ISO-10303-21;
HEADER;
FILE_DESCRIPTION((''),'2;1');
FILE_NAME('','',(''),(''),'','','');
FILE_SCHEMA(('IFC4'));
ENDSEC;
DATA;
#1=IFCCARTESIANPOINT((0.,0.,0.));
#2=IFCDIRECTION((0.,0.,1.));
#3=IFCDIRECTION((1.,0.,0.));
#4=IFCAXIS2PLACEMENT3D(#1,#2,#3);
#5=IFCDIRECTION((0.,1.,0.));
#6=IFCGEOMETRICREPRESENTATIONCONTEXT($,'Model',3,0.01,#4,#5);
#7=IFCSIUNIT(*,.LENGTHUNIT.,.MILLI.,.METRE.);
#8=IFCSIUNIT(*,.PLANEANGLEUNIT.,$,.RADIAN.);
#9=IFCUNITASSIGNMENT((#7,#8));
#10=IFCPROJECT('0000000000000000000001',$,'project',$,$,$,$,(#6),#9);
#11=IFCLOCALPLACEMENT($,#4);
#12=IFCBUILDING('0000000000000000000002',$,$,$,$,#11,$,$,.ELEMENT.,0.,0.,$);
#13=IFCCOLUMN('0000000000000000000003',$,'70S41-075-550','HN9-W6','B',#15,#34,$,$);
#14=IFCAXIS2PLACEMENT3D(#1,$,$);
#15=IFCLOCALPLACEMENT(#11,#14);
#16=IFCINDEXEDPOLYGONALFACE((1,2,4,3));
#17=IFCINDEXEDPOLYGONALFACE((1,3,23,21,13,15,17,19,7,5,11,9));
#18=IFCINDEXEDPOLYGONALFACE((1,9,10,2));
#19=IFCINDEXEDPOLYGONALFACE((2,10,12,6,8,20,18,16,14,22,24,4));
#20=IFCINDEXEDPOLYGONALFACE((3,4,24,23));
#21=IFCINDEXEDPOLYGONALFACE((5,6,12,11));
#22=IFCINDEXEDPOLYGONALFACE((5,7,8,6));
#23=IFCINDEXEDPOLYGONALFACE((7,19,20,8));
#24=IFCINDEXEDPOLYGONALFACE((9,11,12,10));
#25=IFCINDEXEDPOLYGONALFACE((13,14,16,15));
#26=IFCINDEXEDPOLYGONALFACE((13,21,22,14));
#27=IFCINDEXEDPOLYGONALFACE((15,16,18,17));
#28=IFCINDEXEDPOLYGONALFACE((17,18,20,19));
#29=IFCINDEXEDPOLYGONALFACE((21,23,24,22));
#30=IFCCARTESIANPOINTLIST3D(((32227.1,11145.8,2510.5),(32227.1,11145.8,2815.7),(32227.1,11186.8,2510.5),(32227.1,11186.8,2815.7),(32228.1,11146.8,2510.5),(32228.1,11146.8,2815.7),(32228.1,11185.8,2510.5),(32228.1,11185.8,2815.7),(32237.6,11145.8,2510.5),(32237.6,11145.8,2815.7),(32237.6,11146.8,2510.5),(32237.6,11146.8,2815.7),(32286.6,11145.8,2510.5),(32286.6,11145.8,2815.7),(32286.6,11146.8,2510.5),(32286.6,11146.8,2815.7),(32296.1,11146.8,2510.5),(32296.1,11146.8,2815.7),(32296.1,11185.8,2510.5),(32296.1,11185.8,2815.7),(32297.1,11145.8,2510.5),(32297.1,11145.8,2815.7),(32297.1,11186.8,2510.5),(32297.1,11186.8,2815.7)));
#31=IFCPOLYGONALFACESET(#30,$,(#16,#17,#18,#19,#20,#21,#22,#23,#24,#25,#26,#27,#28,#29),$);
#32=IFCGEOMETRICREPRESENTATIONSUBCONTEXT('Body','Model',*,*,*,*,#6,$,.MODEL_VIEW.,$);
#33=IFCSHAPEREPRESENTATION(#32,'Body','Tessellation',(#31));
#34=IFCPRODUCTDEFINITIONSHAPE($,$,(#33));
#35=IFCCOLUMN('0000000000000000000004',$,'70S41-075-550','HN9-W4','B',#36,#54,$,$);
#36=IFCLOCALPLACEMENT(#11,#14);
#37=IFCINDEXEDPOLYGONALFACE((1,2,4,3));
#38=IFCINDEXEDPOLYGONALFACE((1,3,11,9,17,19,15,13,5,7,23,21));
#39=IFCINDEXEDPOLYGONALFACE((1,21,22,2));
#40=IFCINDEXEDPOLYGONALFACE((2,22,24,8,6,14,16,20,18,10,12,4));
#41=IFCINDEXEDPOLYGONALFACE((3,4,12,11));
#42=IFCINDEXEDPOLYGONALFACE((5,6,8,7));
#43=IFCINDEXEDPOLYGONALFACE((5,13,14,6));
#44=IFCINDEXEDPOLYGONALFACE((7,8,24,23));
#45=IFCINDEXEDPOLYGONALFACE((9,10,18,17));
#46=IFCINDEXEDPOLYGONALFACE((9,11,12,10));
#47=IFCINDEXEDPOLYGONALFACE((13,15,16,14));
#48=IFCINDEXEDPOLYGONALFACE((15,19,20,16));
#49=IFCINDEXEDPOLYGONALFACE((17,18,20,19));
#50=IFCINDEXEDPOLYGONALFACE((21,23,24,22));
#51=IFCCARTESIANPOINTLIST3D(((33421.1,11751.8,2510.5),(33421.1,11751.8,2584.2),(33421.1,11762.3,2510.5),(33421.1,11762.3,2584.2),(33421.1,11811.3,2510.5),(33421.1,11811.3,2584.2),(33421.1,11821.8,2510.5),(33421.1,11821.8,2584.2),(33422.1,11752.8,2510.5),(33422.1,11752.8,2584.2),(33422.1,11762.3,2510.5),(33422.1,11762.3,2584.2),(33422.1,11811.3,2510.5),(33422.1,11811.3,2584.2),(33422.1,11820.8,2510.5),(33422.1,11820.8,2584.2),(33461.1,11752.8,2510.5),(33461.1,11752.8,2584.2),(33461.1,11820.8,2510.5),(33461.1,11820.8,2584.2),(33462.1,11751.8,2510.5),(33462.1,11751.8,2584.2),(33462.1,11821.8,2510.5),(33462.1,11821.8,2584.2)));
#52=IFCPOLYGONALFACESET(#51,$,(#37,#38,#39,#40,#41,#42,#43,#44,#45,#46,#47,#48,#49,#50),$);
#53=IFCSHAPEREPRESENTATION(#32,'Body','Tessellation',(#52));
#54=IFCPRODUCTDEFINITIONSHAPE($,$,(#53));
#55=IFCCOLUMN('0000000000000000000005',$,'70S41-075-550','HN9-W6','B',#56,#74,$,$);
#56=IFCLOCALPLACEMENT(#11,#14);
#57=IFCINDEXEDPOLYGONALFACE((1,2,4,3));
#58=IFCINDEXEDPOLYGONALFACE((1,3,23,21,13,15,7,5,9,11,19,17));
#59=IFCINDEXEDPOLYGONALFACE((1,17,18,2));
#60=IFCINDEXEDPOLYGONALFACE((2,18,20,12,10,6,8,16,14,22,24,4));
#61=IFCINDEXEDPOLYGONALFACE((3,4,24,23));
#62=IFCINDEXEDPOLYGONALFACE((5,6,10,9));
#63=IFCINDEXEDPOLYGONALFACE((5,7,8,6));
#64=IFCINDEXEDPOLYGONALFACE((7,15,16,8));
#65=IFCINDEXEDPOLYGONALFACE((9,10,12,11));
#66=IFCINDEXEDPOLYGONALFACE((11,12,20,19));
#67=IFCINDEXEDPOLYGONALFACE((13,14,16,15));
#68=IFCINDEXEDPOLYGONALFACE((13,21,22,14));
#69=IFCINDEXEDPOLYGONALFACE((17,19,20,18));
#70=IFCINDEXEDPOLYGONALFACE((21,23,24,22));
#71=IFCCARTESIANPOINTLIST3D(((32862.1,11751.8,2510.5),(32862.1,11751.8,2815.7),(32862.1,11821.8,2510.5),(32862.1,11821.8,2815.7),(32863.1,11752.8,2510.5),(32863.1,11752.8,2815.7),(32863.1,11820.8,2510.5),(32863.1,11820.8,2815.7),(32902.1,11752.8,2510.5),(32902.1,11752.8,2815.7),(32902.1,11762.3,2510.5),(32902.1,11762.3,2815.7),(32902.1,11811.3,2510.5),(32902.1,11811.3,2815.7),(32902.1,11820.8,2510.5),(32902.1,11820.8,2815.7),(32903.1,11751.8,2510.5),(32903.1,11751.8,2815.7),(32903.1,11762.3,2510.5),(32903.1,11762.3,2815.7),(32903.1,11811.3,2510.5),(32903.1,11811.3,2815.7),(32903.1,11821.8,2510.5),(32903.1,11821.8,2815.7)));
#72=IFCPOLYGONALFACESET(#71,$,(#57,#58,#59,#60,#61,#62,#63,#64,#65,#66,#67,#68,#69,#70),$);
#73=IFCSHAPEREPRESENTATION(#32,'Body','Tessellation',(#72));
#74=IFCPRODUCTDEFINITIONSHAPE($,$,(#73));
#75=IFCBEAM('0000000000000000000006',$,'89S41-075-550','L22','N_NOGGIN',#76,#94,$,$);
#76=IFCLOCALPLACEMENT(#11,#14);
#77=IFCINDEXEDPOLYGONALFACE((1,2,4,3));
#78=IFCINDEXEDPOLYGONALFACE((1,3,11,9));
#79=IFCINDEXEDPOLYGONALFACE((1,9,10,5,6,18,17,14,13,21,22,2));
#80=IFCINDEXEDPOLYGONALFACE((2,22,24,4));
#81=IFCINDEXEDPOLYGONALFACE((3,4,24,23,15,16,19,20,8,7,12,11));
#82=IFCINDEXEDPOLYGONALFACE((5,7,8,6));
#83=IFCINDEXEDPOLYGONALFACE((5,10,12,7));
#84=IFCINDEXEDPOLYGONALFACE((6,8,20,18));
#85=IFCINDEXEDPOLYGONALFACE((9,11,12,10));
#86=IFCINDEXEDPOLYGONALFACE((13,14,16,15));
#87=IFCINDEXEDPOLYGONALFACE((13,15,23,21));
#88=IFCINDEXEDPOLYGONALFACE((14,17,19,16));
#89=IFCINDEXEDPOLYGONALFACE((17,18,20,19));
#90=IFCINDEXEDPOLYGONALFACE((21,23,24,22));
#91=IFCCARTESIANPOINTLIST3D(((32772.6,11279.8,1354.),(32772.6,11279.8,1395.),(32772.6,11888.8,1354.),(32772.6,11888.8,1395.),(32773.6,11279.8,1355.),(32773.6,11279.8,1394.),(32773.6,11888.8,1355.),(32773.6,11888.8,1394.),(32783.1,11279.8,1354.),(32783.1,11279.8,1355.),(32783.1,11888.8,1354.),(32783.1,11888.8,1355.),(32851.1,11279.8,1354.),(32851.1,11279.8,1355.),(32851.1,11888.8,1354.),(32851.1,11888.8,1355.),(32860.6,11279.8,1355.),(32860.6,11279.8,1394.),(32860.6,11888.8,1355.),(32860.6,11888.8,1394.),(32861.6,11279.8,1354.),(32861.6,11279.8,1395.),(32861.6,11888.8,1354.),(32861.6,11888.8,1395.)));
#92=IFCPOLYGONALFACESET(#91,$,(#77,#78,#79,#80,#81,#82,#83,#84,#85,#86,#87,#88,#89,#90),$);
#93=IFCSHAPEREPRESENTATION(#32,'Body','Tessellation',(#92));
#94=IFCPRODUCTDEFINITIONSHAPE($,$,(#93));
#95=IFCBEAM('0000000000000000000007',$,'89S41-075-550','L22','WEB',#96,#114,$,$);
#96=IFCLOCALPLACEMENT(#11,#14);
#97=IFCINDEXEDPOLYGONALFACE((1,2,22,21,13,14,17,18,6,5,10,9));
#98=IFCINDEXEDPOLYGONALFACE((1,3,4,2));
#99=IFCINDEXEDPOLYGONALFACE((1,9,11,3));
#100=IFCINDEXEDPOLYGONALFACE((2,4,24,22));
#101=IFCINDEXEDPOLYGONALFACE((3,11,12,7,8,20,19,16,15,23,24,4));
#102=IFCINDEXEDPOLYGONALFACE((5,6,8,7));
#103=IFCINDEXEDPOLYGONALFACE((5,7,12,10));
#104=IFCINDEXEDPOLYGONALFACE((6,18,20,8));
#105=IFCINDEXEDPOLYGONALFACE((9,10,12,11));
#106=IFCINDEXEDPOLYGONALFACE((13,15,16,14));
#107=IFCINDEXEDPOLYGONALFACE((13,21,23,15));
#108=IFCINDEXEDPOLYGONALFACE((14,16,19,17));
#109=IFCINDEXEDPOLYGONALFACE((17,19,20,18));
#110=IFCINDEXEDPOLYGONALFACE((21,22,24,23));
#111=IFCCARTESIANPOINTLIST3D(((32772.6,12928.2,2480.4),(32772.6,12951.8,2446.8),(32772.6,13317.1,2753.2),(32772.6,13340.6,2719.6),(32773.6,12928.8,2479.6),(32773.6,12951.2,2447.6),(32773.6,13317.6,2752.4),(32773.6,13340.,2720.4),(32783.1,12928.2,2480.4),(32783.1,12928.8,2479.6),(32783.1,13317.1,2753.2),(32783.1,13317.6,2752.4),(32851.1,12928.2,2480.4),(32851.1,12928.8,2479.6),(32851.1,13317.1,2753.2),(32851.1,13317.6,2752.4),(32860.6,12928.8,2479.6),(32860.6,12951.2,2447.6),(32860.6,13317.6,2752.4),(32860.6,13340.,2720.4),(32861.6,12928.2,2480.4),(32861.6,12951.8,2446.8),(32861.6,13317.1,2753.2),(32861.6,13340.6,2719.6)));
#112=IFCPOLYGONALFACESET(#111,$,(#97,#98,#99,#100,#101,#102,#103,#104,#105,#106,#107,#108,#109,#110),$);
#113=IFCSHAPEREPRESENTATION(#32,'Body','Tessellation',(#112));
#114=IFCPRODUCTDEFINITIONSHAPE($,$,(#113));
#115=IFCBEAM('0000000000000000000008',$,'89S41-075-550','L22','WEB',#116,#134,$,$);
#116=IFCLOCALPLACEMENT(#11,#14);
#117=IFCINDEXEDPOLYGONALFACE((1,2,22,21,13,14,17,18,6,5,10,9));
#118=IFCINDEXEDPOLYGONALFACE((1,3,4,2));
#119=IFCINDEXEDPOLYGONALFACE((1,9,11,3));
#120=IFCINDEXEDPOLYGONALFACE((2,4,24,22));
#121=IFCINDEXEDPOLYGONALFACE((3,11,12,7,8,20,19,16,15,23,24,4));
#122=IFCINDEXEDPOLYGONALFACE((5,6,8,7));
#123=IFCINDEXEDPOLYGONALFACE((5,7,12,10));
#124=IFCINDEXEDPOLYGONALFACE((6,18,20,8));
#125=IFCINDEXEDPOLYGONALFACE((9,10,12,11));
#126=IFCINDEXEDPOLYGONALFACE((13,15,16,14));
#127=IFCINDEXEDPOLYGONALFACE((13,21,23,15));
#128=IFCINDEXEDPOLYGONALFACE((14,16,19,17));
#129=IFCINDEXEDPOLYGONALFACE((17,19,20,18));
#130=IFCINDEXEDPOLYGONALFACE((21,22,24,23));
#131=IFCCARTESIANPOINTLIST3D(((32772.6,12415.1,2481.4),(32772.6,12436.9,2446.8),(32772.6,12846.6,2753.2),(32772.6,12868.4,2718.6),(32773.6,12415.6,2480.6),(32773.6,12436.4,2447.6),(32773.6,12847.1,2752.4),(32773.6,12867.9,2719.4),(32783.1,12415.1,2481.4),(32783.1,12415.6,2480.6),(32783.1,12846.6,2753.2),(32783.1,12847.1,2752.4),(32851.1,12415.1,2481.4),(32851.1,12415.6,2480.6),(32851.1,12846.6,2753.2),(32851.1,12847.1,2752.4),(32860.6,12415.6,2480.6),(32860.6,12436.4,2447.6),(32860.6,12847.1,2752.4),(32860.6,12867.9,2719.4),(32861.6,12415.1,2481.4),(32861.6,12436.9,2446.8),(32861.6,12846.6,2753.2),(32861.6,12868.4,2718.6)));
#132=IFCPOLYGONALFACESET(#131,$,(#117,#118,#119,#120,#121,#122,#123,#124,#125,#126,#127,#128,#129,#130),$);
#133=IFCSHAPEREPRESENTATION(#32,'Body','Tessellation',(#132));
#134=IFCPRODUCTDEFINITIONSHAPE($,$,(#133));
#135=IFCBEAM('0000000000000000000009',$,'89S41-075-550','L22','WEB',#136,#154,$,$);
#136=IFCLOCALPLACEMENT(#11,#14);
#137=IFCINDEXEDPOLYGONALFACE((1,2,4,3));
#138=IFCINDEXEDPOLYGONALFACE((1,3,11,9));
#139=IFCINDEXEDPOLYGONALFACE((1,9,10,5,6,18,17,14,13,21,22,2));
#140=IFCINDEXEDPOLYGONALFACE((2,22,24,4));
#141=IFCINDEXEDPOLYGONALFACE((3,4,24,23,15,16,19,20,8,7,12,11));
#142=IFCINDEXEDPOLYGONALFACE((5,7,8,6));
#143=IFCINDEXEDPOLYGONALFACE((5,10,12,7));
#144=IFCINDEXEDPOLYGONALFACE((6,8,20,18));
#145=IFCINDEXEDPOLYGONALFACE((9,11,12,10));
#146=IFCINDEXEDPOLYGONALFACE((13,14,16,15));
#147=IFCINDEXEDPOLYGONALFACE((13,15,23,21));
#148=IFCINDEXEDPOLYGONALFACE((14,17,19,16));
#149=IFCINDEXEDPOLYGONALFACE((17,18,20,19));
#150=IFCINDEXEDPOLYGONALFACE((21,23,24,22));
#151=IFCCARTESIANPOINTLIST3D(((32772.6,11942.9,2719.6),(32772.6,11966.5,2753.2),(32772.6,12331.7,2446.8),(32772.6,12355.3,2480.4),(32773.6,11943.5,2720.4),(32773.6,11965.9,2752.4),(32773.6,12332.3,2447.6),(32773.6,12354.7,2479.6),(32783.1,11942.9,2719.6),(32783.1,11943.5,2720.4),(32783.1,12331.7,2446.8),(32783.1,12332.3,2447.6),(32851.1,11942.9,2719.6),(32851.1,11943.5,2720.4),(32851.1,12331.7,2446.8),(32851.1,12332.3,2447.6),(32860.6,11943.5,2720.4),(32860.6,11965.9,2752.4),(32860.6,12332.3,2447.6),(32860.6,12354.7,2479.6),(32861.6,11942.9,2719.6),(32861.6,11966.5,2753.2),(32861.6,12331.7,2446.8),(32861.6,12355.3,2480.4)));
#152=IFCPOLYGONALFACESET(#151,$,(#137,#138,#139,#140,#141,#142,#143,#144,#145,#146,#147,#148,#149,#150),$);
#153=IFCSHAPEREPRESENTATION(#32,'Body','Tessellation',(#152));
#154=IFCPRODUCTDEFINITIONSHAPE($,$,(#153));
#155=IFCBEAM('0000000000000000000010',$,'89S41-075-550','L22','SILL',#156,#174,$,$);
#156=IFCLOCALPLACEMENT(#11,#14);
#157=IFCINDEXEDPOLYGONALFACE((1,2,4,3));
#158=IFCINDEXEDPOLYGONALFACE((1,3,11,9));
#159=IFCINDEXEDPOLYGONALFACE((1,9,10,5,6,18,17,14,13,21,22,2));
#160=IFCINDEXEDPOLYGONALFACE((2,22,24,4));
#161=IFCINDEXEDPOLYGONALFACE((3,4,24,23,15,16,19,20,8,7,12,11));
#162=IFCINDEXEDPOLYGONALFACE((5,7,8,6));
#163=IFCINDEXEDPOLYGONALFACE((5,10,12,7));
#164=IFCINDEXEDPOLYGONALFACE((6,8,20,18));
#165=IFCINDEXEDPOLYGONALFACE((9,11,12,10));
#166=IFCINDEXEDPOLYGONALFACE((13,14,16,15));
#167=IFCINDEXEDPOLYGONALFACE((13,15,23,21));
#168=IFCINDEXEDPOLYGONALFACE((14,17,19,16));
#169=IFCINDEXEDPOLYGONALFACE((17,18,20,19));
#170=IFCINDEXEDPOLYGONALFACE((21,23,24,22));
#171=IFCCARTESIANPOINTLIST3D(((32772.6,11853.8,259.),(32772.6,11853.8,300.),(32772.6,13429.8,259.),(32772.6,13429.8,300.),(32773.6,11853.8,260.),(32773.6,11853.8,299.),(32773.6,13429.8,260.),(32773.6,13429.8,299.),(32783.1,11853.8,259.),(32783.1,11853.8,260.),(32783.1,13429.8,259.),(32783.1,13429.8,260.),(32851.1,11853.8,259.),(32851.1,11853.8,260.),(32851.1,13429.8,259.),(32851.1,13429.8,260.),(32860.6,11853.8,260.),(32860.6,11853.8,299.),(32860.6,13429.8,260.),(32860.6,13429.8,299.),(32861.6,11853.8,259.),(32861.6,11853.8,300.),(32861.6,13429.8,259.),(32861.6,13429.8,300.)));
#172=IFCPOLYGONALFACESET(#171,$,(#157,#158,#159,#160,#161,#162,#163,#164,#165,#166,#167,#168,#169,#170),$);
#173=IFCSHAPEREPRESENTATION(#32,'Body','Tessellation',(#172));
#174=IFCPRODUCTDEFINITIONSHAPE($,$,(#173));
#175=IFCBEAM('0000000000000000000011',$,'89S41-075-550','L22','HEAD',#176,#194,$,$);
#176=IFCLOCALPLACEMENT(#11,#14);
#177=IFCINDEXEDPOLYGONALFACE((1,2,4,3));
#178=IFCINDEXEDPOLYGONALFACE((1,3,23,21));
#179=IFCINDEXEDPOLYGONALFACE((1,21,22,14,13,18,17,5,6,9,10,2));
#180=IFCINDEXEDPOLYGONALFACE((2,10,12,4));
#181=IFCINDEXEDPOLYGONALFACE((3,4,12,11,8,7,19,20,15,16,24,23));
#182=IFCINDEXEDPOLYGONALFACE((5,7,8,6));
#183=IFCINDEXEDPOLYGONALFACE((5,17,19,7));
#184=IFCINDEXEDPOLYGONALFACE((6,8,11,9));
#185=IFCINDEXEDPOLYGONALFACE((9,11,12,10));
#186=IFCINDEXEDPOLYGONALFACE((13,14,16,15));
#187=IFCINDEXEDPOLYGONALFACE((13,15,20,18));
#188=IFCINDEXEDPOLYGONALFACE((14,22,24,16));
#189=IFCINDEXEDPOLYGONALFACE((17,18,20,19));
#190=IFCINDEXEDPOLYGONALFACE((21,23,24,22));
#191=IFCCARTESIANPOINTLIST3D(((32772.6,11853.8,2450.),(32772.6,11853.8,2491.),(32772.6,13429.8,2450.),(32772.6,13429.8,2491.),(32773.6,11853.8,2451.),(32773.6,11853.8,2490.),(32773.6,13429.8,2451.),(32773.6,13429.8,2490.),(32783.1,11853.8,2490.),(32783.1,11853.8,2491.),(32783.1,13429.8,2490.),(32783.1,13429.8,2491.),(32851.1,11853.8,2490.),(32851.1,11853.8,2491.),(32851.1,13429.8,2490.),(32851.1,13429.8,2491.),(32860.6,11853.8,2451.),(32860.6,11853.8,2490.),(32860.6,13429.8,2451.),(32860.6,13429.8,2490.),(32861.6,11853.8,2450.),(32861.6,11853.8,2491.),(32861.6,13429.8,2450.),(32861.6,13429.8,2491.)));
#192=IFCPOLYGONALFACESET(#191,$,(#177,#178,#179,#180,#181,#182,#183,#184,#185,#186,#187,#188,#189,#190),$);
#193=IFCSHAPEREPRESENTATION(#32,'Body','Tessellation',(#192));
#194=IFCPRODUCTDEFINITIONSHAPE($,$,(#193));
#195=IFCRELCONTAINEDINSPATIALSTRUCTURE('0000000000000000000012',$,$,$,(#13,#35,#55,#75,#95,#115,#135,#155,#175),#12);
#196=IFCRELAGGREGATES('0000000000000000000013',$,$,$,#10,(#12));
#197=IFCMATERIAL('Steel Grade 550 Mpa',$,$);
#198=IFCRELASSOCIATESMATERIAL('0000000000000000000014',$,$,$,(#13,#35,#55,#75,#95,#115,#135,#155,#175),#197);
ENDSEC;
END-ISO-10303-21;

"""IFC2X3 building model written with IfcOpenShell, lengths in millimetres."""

from ifc_helpers import new_model, si_unit, direction, frame, origin, origin_with_axes, origin_2d_with_axis, place, context, subcontext, project, spatial, c_section, extrude, source, transform, mapped, material, element, save


model = new_model("IFC2X3")

# Units and contexts
model_context = context("Model", 3, precision=0.01, world=origin_with_axes(), true_north=direction((0.0, 1.0, 0.0)))
body_context = subcontext(model_context, "Body", "Model", "MODEL_VIEW")
ifc_project = project(units=[si_unit("LENGTHUNIT", "METRE", prefix="MILLI"), si_unit("PLANEANGLEUNIT", "RADIAN")], contexts=[model_context])

# Building
building_placement = place(None, origin_with_axes())
building = spatial("IfcBuilding", under=ifc_project, at=building_placement, CompositionType="ELEMENT", ElevationOfRefHeight=0.0, ElevationOfTerrain=0.0)

# Columns
ifc_material = material(Name="Steel Grade 550 Mpa")
shared_shape_1 = source(origin(), body_context, "Body", "SweptSolid", [
    extrude(c_section(Depth=70.0, Width=41.0, WallThickness=1.0, Girth=10.5, at=origin_2d_with_axis()), origin_with_axes(), (0.0, 0.0, 1.0), 305.2),
])
column_1_placement = place(None, frame((32262.1, 11166.3, 2510.5), z_axis=(0.0, 0.0, 1.0), x_axis=(0.0, -1.0, 0.0)))
element("IfcColumn", 1, at=column_1_placement, inside=building, material=ifc_material, Name="70S41-075-550", Description="HN9-W6", ObjectType="B", context=body_context, shape_type="MappedRepresentation", body=[
    mapped(shared_shape_1, transform((0.0, 0.0, 0.0), scale=1.0)),
])
shared_shape_2 = source(origin(), body_context, "Body", "SweptSolid", [
    extrude(c_section(Depth=70.0, Width=41.0, WallThickness=1.0, Girth=10.5, at=origin_2d_with_axis()), origin_with_axes(), (0.0, 0.0, 1.0), 73.7),
])
column_2_placement = place(None, frame((33441.6, 11786.8, 2584.2), z_axis=(0.0, 0.0, -1.0), x_axis=(-1.0, 0.0, 0.0)))
element("IfcColumn", 2, at=column_2_placement, inside=building, material=ifc_material, Name="70S41-075-550", Description="HN9-W4", ObjectType="B", context=body_context, shape_type="MappedRepresentation", body=[
    mapped(shared_shape_2, transform((0.0, 0.0, 0.0), scale=1.0)),
])
shared_shape_3 = source(origin(), body_context, "Body", "SweptSolid", [
    extrude(c_section(Depth=70.0, Width=41.0, WallThickness=1.0, Girth=10.5, at=origin_2d_with_axis()), origin_with_axes(), (0.0, 0.0, 1.0), 305.2),
])
column_3_placement = place(None, frame((32882.6, 11786.8, 2510.5), z_axis=(0.0, 0.0, 1.0), x_axis=(1.0, 0.0, 0.0)))
element("IfcColumn", 3, at=column_3_placement, inside=building, material=ifc_material, Name="70S41-075-550", Description="HN9-W6", ObjectType="B", context=body_context, shape_type="MappedRepresentation", body=[
    mapped(shared_shape_3, transform((0.0, 0.0, 0.0), scale=1.0)),
])

# Beams
shared_shape_4 = source(origin(), body_context, "Body", "SweptSolid", [
    extrude(c_section(Depth=89.0, Width=41.0, WallThickness=1.0, Girth=10.5, at=origin_2d_with_axis()), origin_with_axes(), (0.0, 0.0, 1.0), 609.0),
])
beam_1_placement = place(None, frame((32817.1, 11279.8, 1374.5), z_axis=(0.0, 1.0, 0.0), x_axis=(0.0, 0.0, -1.0)))
element("IfcBeam", 4, at=beam_1_placement, inside=building, material=ifc_material, Name="89S41-075-550", Description="L22", ObjectType="N_NOGGIN", context=body_context, shape_type="MappedRepresentation", body=[
    mapped(shared_shape_4, transform((0.0, 0.0, 0.0), scale=1.0)),
])
shared_shape_5 = source(origin(), body_context, "Body", "SweptSolid", [
    extrude(c_section(Depth=89.0, Width=41.0, WallThickness=1.0, Girth=10.5, at=origin_2d_with_axis()), origin_with_axes(), (0.0, 0.0, 1.0), 475.0),
])
beam_2_placement = place(None, frame((32817.1, 12940.0, 2463.6), z_axis=(0.0, 0.818621, 0.574335), x_axis=(0.0, -0.574335, 0.818621)))
element("IfcBeam", 5, at=beam_2_placement, inside=building, material=ifc_material, Name="89S41-075-550", Description="L22", ObjectType="WEB", context=body_context, shape_type="MappedRepresentation", body=[
    mapped(shared_shape_5, transform((0.0, 0.0, 0.0), scale=1.0)),
])
shared_shape_6 = source(origin(), body_context, "Body", "SweptSolid", [
    extrude(c_section(Depth=89.0, Width=41.0, WallThickness=1.0, Girth=10.5, at=origin_2d_with_axis()), origin_with_axes(), (0.0, 0.0, 1.0), 509.9),
])
beam_3_placement = place(None, frame((32817.1, 12426.0, 2464.1), z_axis=(0.0, 0.846123, 0.532988), x_axis=(0.0, -0.532988, 0.846123)))
element("IfcBeam", 6, at=beam_3_placement, inside=building, material=ifc_material, Name="89S41-075-550", Description="L22", ObjectType="WEB", context=body_context, shape_type="MappedRepresentation", body=[
    mapped(shared_shape_6, transform((0.0, 0.0, 0.0), scale=1.0)),
])
shared_shape_7 = source(origin(), body_context, "Body", "SweptSolid", [
    extrude(c_section(Depth=89.0, Width=41.0, WallThickness=1.0, Girth=10.5, at=origin_2d_with_axis()), origin_with_axes(), (0.0, 0.0, 1.0), 475.0),
])
beam_4_placement = place(None, frame((32817.1, 12343.5, 2463.6), z_axis=(0.0, -0.818628, 0.574324), x_axis=(0.0, -0.574324, -0.818628)))
element("IfcBeam", 7, at=beam_4_placement, inside=building, material=ifc_material, Name="89S41-075-550", Description="L22", ObjectType="WEB", context=body_context, shape_type="MappedRepresentation", body=[
    mapped(shared_shape_7, transform((0.0, 0.0, 0.0), scale=1.0)),
])
shared_shape_8 = source(origin(), body_context, "Body", "SweptSolid", [
    extrude(c_section(Depth=89.0, Width=41.0, WallThickness=1.0, Girth=10.5, at=origin_2d_with_axis()), origin_with_axes(), (0.0, 0.0, 1.0), 1576.0),
])
beam_5_placement = place(None, frame((32817.1, 11853.8, 279.5), z_axis=(0.0, 1.0, 0.0), x_axis=(0.0, 0.0, -1.0)))
element("IfcBeam", 8, at=beam_5_placement, inside=building, material=ifc_material, Name="89S41-075-550", Description="L22", ObjectType="SILL", context=body_context, shape_type="MappedRepresentation", body=[
    mapped(shared_shape_8, transform((0.0, 0.0, 0.0), scale=1.0)),
])
shared_shape_9 = source(origin(), body_context, "Body", "SweptSolid", [
    extrude(c_section(Depth=89.0, Width=41.0, WallThickness=1.0, Girth=10.5, at=origin_2d_with_axis()), origin_with_axes(), (0.0, 0.0, 1.0), 1576.0),
])
beam_6_placement = place(None, frame((32817.1, 11853.8, 2470.5), z_axis=(0.0, 1.0, 0.0), x_axis=(0.0, 0.0, 1.0)))
element("IfcBeam", 9, at=beam_6_placement, inside=building, material=ifc_material, Name="89S41-075-550", Description="L22", ObjectType="HEAD", context=body_context, shape_type="MappedRepresentation", body=[
    mapped(shared_shape_9, transform((0.0, 0.0, 0.0), scale=1.0)),
])

save(model, "model.ifc")
